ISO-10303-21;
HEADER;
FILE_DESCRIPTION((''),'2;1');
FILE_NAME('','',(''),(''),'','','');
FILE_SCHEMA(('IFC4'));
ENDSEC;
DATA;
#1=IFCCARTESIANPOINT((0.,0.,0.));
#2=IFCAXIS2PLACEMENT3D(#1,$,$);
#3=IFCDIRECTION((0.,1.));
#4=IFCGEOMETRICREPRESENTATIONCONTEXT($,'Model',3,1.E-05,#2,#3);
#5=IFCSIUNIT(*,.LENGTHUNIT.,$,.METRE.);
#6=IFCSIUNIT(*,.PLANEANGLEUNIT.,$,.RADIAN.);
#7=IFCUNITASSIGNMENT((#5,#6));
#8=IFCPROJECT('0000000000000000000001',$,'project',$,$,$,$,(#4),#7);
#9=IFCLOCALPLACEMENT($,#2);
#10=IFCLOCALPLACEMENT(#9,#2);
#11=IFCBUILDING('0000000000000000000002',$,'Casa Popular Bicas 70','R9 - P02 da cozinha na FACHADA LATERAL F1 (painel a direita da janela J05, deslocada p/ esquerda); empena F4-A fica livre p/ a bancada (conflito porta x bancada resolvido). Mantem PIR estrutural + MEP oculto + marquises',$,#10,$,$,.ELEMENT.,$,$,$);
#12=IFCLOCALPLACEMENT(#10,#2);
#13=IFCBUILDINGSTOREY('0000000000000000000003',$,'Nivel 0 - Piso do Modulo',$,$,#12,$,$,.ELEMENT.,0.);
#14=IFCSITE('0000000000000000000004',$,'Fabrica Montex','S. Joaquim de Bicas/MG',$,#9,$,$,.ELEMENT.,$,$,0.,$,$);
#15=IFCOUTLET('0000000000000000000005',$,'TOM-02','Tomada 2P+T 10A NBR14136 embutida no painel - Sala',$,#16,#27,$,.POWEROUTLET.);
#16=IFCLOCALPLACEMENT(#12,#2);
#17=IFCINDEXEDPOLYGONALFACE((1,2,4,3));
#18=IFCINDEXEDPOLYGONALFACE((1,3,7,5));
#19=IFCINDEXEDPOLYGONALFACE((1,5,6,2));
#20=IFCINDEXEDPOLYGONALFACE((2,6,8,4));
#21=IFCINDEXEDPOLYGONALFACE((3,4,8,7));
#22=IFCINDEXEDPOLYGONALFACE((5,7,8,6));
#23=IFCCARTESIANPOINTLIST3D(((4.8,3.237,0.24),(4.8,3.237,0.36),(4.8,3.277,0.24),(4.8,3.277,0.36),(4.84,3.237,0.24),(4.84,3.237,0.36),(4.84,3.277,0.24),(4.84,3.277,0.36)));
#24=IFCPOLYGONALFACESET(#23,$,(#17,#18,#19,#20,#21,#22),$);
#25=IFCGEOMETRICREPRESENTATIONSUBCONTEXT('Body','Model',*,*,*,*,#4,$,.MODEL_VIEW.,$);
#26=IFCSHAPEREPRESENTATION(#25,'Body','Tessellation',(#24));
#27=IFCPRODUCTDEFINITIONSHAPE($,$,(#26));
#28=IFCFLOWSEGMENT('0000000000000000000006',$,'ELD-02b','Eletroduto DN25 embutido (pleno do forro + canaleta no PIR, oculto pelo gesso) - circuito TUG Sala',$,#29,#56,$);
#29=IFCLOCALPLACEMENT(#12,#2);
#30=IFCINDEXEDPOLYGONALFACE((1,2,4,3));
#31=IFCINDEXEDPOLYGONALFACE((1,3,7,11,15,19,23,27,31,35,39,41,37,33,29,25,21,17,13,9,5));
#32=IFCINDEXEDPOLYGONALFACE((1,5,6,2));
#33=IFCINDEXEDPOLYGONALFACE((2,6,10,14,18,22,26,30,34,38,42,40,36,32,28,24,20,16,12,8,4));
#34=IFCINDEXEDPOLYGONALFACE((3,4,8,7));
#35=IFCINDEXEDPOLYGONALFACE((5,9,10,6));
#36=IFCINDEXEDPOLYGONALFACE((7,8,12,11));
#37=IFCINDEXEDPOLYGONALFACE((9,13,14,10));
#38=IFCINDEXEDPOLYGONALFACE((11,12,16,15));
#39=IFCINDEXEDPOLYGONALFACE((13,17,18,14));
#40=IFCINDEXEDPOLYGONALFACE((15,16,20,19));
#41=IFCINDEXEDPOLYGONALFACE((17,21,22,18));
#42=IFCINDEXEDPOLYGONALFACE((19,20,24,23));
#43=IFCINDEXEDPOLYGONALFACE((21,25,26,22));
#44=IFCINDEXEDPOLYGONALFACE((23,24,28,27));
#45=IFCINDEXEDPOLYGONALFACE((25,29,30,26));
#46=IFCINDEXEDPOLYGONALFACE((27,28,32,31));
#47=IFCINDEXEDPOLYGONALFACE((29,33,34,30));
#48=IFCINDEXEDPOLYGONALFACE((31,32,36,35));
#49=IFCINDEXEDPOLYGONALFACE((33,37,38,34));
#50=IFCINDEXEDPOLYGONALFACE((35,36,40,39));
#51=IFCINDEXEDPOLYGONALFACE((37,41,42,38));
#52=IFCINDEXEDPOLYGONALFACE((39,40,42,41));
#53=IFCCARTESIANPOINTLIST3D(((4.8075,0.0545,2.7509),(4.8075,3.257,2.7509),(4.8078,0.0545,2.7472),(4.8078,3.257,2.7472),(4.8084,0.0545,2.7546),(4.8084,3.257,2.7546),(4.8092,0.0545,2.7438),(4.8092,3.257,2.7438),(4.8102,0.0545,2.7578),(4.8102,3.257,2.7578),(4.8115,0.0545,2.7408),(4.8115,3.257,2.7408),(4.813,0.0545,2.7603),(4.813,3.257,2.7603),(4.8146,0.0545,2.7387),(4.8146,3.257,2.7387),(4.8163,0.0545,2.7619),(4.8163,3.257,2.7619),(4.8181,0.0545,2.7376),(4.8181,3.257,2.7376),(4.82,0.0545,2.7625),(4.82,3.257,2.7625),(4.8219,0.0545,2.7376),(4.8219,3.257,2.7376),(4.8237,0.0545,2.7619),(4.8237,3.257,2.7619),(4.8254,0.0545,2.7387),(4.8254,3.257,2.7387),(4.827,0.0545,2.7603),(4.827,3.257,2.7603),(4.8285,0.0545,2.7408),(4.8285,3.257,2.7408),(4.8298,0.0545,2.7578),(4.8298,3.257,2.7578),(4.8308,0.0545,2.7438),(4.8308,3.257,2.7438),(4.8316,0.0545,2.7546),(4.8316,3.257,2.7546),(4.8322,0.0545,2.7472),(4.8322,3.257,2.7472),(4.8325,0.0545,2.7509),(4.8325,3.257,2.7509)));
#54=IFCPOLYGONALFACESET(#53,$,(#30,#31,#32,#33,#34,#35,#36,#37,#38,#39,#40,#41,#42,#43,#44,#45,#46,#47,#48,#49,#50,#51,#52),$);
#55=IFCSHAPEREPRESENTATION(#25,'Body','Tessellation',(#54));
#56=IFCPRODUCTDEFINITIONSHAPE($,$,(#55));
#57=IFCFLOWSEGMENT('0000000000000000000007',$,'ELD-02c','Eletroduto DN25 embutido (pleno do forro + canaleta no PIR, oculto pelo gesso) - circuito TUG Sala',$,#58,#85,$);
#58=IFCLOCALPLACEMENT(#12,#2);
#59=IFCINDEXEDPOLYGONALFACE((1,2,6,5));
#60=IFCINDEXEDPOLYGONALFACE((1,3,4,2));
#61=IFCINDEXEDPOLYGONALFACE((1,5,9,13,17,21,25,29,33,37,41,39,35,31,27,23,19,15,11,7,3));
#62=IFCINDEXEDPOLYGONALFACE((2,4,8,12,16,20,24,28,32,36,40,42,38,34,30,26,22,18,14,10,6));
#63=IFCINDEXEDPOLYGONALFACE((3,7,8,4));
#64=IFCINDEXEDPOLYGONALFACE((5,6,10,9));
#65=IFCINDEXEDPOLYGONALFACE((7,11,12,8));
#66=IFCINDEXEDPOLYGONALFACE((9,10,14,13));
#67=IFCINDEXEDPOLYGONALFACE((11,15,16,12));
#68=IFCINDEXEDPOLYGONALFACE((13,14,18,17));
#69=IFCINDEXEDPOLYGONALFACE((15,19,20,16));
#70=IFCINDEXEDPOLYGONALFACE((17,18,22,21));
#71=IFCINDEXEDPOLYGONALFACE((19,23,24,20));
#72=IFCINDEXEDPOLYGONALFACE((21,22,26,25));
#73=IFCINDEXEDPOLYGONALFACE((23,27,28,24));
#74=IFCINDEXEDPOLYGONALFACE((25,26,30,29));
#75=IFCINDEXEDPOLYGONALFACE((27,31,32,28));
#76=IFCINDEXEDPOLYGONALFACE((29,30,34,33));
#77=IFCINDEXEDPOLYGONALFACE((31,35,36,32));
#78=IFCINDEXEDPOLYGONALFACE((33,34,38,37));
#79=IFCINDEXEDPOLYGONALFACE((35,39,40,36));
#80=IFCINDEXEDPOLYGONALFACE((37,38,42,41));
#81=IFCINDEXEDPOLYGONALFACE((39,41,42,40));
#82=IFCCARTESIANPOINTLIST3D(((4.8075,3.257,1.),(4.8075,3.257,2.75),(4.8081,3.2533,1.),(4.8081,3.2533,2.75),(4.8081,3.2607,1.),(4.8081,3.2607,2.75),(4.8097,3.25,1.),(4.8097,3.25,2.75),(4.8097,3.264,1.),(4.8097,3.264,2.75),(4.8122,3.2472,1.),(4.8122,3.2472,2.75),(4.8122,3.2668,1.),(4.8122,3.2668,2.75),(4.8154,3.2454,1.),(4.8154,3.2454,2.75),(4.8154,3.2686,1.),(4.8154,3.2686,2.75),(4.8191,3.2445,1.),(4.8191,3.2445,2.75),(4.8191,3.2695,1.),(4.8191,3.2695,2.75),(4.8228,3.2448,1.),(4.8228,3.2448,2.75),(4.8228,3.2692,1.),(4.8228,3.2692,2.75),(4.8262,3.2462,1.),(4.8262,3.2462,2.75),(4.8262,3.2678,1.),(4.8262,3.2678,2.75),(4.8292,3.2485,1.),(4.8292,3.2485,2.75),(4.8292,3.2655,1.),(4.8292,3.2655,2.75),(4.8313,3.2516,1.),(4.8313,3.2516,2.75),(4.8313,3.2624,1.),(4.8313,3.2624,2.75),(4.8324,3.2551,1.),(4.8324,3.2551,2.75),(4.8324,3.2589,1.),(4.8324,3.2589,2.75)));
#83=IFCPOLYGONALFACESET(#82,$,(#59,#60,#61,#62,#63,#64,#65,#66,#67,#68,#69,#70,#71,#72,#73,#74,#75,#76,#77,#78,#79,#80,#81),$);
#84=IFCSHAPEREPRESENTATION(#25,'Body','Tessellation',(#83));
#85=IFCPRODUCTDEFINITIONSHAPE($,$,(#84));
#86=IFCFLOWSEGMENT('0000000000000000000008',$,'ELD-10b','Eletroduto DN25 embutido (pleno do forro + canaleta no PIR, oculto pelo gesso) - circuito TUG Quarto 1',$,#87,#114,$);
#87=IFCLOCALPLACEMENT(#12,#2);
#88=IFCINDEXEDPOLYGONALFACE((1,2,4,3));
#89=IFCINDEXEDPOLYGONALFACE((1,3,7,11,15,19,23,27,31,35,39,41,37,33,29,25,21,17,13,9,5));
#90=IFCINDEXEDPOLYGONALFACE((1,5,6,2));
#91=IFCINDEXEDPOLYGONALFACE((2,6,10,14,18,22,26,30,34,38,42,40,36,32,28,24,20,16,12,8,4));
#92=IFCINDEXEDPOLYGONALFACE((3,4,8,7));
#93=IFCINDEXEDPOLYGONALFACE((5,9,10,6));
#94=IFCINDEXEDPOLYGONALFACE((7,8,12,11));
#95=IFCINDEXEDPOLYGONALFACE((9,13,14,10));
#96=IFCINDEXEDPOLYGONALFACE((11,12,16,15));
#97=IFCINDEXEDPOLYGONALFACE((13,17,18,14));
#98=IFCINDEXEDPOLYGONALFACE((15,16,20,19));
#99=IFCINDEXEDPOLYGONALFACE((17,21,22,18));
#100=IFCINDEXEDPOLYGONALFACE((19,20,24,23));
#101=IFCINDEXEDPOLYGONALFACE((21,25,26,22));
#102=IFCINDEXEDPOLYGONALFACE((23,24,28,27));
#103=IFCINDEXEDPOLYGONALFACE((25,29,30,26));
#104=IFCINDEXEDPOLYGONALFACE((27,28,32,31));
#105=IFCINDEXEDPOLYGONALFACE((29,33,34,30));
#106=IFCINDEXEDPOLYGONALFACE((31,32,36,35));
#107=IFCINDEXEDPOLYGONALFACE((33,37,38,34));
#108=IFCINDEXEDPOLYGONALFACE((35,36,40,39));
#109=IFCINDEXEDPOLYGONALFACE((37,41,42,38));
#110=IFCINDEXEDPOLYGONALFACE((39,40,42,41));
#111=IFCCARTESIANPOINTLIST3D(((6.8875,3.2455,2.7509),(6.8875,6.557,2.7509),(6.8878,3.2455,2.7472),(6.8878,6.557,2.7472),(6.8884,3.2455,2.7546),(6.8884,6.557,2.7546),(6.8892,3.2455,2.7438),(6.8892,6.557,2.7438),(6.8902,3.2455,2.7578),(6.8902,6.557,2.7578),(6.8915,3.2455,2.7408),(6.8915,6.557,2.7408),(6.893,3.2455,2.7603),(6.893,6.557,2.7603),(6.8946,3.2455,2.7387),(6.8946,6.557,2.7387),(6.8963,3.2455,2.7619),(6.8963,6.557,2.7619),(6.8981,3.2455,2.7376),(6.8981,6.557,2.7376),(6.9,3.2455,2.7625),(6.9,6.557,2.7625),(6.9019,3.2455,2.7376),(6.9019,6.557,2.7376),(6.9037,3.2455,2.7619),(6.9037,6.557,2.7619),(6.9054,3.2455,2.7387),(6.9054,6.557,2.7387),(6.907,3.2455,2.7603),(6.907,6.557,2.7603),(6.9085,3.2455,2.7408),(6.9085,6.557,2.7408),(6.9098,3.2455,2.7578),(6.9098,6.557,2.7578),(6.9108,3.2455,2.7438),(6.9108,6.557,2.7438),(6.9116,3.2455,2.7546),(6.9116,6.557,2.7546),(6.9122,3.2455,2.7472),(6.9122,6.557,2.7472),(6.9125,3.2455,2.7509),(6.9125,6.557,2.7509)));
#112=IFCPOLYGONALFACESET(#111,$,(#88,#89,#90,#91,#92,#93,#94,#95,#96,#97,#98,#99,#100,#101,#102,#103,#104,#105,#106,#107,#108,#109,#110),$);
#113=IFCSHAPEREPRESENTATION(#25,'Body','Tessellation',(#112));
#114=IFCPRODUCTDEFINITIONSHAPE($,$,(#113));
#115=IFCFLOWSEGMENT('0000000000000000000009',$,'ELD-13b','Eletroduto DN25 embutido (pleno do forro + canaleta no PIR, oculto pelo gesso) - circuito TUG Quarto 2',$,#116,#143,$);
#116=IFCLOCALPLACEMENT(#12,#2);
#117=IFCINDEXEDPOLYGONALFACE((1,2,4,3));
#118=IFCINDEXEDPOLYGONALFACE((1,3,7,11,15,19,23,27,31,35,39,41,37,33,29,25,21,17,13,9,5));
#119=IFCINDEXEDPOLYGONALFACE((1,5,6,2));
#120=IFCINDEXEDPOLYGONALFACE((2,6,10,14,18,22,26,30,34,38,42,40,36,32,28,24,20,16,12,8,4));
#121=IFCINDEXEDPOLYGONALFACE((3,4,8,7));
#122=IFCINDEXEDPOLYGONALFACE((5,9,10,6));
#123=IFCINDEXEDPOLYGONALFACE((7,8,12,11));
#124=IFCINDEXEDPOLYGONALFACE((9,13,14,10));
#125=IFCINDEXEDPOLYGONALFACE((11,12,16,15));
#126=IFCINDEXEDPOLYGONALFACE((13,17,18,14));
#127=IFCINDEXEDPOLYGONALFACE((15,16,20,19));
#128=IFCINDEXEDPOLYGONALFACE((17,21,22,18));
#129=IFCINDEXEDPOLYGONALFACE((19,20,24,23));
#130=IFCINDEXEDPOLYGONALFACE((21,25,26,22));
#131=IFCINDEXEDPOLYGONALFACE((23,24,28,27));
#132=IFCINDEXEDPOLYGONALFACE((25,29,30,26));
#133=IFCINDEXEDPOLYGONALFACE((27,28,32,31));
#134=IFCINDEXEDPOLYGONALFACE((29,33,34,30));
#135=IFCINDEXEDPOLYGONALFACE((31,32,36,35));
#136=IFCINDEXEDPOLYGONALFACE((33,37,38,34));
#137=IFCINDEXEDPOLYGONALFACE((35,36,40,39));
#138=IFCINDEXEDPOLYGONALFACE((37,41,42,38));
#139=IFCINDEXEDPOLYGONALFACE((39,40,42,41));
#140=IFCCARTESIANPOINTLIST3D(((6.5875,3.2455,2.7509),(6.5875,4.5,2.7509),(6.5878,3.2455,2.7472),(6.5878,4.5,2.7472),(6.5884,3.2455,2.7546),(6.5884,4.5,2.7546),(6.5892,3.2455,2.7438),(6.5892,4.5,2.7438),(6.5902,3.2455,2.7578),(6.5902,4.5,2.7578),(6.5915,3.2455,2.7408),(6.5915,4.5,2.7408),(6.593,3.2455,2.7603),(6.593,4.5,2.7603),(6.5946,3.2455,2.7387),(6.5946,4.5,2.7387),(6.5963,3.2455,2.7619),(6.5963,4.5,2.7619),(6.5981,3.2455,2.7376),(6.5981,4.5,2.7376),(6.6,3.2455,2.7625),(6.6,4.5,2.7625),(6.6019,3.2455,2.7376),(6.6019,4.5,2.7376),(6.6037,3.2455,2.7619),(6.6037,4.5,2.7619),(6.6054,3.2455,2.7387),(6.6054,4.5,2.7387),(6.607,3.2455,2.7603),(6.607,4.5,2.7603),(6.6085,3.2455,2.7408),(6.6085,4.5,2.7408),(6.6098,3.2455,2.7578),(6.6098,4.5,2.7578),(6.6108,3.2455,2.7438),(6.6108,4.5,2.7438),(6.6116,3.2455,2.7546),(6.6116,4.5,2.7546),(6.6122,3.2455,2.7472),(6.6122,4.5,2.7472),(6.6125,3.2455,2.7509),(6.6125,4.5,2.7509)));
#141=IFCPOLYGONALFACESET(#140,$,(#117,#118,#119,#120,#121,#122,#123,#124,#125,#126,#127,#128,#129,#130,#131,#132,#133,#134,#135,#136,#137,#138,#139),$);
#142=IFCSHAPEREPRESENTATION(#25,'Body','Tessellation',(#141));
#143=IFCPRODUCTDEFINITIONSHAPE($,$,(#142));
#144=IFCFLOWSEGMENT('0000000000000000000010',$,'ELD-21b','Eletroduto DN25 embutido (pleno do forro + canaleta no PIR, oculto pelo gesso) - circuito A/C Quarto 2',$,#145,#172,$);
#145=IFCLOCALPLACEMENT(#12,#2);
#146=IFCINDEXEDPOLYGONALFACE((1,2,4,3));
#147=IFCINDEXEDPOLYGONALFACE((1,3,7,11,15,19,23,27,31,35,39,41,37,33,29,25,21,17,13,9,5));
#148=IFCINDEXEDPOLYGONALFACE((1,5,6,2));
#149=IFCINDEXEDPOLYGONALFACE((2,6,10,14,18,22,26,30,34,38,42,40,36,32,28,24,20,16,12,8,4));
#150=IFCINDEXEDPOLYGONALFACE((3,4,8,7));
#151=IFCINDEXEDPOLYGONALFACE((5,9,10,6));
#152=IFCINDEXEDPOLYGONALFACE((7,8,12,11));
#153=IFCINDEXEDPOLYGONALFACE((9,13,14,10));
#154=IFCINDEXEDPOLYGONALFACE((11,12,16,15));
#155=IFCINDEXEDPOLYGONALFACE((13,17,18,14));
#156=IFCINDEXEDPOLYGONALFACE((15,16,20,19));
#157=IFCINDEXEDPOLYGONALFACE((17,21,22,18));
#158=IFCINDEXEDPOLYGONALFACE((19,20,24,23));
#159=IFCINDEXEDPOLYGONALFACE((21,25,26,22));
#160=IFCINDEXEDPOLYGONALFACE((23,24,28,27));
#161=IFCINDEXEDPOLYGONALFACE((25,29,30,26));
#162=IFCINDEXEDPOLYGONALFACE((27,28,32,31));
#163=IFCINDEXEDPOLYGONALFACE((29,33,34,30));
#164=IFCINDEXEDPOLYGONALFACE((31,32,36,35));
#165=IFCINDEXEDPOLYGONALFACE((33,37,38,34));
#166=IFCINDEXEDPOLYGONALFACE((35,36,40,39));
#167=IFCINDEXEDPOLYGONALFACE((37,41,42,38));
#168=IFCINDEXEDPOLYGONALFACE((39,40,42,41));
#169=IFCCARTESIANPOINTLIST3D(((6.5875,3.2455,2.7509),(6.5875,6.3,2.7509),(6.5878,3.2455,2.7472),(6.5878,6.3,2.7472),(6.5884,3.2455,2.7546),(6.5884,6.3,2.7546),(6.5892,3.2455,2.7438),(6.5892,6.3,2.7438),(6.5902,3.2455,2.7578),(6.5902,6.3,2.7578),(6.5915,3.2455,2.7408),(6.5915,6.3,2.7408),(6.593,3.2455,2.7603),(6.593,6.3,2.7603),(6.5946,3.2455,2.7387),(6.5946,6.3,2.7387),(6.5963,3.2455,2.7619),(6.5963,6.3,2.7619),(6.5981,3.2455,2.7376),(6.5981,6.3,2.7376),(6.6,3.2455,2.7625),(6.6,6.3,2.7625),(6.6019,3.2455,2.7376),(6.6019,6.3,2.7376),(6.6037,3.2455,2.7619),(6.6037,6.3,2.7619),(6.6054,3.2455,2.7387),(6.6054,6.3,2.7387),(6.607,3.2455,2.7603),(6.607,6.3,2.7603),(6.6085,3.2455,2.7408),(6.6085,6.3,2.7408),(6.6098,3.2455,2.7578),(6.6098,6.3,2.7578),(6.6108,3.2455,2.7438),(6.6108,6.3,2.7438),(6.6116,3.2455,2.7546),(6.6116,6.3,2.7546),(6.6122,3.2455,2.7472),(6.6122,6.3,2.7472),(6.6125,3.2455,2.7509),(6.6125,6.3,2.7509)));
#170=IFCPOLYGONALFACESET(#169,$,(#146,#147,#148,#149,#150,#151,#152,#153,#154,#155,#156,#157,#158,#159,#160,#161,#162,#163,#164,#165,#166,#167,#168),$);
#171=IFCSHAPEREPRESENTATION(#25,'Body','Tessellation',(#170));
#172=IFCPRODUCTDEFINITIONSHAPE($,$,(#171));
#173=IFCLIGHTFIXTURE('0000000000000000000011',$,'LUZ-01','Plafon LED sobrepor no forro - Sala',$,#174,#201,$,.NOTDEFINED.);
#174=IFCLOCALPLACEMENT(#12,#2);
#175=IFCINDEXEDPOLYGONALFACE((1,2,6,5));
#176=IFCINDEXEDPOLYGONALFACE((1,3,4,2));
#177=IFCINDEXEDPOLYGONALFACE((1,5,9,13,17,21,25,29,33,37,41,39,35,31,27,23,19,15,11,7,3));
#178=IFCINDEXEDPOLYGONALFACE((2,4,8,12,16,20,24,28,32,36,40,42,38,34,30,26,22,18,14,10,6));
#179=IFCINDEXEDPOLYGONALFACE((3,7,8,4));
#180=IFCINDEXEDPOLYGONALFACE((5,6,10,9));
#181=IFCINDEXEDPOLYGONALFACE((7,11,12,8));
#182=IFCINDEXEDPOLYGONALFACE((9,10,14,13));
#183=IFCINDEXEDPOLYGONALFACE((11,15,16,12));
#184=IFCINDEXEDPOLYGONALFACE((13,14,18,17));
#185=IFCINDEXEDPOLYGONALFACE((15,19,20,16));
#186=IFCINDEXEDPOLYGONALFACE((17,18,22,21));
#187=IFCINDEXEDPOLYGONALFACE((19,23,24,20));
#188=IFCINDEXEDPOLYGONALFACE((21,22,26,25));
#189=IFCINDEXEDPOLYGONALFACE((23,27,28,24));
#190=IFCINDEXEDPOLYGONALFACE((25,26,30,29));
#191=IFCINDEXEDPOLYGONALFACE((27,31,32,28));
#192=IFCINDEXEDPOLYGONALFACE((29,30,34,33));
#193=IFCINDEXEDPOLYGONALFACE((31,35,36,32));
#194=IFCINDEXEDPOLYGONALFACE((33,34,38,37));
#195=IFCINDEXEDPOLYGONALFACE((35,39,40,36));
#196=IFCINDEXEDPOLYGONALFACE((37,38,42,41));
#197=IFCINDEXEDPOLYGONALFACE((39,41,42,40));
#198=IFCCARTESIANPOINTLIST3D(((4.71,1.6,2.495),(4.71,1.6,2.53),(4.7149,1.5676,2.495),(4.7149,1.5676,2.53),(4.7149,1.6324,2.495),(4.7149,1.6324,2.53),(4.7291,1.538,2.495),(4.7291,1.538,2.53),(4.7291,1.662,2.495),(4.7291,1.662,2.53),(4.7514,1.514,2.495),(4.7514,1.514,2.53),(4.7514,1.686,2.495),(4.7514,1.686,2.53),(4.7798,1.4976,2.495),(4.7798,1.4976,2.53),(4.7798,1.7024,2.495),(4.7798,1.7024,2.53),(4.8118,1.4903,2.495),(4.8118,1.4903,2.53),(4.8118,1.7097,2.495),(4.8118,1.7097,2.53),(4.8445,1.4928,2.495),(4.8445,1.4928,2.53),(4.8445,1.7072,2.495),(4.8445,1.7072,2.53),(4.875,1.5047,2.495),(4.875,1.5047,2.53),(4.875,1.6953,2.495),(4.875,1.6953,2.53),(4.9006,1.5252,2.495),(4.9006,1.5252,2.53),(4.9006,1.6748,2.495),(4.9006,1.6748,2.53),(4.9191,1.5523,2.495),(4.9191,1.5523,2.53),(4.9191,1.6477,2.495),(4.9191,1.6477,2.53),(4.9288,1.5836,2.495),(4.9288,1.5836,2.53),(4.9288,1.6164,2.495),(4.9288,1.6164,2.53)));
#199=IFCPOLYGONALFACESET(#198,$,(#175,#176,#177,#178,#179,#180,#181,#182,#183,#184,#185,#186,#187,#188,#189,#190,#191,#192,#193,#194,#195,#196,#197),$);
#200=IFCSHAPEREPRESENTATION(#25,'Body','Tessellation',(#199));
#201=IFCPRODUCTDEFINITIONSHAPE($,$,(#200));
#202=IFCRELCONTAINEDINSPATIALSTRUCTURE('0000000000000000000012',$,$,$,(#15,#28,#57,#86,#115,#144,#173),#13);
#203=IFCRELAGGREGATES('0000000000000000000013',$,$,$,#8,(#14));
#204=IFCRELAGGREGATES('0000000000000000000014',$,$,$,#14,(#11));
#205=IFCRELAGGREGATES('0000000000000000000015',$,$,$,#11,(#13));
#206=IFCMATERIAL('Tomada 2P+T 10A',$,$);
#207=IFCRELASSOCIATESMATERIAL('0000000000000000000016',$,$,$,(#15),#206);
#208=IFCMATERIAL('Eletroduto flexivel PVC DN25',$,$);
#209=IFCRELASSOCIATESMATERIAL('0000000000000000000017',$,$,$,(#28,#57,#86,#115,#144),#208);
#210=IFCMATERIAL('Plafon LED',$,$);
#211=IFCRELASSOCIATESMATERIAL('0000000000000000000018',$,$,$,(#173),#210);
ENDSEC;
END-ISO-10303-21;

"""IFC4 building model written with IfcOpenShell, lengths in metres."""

from ifc_helpers import new_model, si_unit, direction, frame, frame_2d, origin, origin_2d, place, context, subcontext, project, spatial, rectangle, circle, extrude, material, element, save


model = new_model("IFC4")

# Units and contexts
model_context = context("Model", 3, precision=1e-05, world=origin(), true_north=direction((0.0, 1.0)))
body_context = subcontext(model_context, "Body", "Model", "MODEL_VIEW")
ifc_project = project(units=[si_unit("LENGTHUNIT", "METRE"), si_unit("PLANEANGLEUNIT", "RADIAN")], contexts=[model_context])

# Site, building, storey
site_placement = place(None, origin())
site = spatial("IfcSite", under=ifc_project, at=site_placement, Name="Fabrica Montex", Description="S. Joaquim de Bicas/MG", CompositionType="ELEMENT", RefElevation=0.0)
building_placement = place(site_placement, origin())
building = spatial("IfcBuilding", under=site, at=building_placement, Name="Casa Popular Bicas 70", Description="R9 - P02 da cozinha na FACHADA LATERAL F1 (painel a direita da janela J05, deslocada p/ esquerda); empena F4-A fica livre p/ a bancada (conflito porta x bancada resolvido). Mantem PIR estrutural + MEP oculto + marquises", CompositionType="ELEMENT")
storey_placement = place(building_placement, origin())
storey = spatial("IfcBuildingStorey", under=building, at=storey_placement, Name="Nivel 0 - Piso do Modulo", CompositionType="ELEMENT", Elevation=0.0)

# Shared definitions
ifc_material_1 = material(Name="Tomada 2P+T 10A")

# Shared definitions
ifc_material_2 = material(Name="Eletroduto flexivel PVC DN25")

# Outlet
outlet_1_placement = place(None, frame((4.84, 3.277, 0.24), z_axis=(0.0, 0.0, 1.0), x_axis=(-1.0, 0.0, 0.0)))
element("IfcOutlet", 1, at=outlet_1_placement, inside=storey, material=ifc_material_1, Name="TOM-02", Description="Tomada 2P+T 10A NBR14136 embutida no painel - Sala", PredefinedType="POWEROUTLET", context=body_context, shape_type="SweptSolid", body=[
    extrude(rectangle(XDim=0.04, YDim=0.04, at=frame_2d((0.02, 0.02))), origin(), (0.0, 0.0, 1.0), 0.12),
])

# Flow segments
flow_segment_1_placement = place(None, frame((4.82, 0.0545, 2.75), z_axis=(0.0, 1.0, 0.0), x_axis=(0.0, 0.0, 1.0)))
element("IfcFlowSegment", 2, at=flow_segment_1_placement, inside=storey, material=ifc_material_2, Name="ELD-02b", Description="Eletroduto DN25 embutido (pleno do forro + canaleta no PIR, oculto pelo gesso) - circuito TUG Sala", context=body_context, shape_type="SweptSolid", body=[
    extrude(circle(Radius=0.0125, at=origin_2d()), origin(), (0.0, 0.0, 1.0), 3.2025),
])
flow_segment_2_placement = place(None, frame((4.82, 3.257, 2.75), z_axis=(0.0, 0.0, -1.0), x_axis=(-1.0, 0.0, 0.0)))
element("IfcFlowSegment", 3, at=flow_segment_2_placement, inside=storey, material=ifc_material_2, Name="ELD-02c", Description="Eletroduto DN25 embutido (pleno do forro + canaleta no PIR, oculto pelo gesso) - circuito TUG Sala", context=body_context, shape_type="SweptSolid", body=[
    extrude(circle(Radius=0.0125, at=origin_2d()), origin(), (0.0, 0.0, 1.0), 1.75),
])
flow_segment_3_placement = place(storey_placement, frame((6.9, 3.2455, 2.75), z_axis=(0.0, 1.0, 0.0), x_axis=(0.0, 0.0, 1.0)))
element("IfcFlowSegment", 4, at=flow_segment_3_placement, inside=storey, material=ifc_material_2, Name="ELD-10b", Description="Eletroduto DN25 embutido (pleno do forro + canaleta no PIR, oculto pelo gesso) - circuito TUG Quarto 1", context=body_context, shape_type="SweptSolid", body=[
    extrude(circle(Radius=0.0125, at=origin_2d()), origin(), (0.0, 0.0, 1.0), 3.3115),
])
flow_segment_4_placement = place(storey_placement, frame((6.6, 3.2455, 2.75), z_axis=(0.0, 1.0, 0.0), x_axis=(0.0, 0.0, 1.0)))
element("IfcFlowSegment", 5, at=flow_segment_4_placement, inside=storey, material=ifc_material_2, Name="ELD-13b", Description="Eletroduto DN25 embutido (pleno do forro + canaleta no PIR, oculto pelo gesso) - circuito TUG Quarto 2", context=body_context, shape_type="SweptSolid", body=[
    extrude(circle(Radius=0.0125, at=origin_2d()), origin(), (0.0, 0.0, 1.0), 1.2545),
])
flow_segment_5_placement = place(storey_placement, frame((6.6, 3.2455, 2.75), z_axis=(0.0, 1.0, 0.0), x_axis=(0.0, 0.0, 1.0)))
element("IfcFlowSegment", 6, at=flow_segment_5_placement, inside=storey, material=ifc_material_2, Name="ELD-21b", Description="Eletroduto DN25 embutido (pleno do forro + canaleta no PIR, oculto pelo gesso) - circuito A/C Quarto 2", context=body_context, shape_type="SweptSolid", body=[
    extrude(circle(Radius=0.0125, at=origin_2d()), origin(), (0.0, 0.0, 1.0), 3.0545),
])

# Light fixture
ifc_material_3 = material(Name="Plafon LED")
light_fixture_placement = place(None, frame((4.82, 1.6, 2.495), z_axis=(0.0, 0.0, 1.0), x_axis=(-1.0, 0.0, 0.0)))
element("IfcLightFixture", 7, at=light_fixture_placement, inside=storey, material=ifc_material_3, Name="LUZ-01", Description="Plafon LED sobrepor no forro - Sala", PredefinedType="NOTDEFINED", context=body_context, shape_type="SweptSolid", body=[
    extrude(circle(Radius=0.11, at=origin_2d()), origin(), (0.0, 0.0, 1.0), 0.035),
])

save(model, "model.ifc")
